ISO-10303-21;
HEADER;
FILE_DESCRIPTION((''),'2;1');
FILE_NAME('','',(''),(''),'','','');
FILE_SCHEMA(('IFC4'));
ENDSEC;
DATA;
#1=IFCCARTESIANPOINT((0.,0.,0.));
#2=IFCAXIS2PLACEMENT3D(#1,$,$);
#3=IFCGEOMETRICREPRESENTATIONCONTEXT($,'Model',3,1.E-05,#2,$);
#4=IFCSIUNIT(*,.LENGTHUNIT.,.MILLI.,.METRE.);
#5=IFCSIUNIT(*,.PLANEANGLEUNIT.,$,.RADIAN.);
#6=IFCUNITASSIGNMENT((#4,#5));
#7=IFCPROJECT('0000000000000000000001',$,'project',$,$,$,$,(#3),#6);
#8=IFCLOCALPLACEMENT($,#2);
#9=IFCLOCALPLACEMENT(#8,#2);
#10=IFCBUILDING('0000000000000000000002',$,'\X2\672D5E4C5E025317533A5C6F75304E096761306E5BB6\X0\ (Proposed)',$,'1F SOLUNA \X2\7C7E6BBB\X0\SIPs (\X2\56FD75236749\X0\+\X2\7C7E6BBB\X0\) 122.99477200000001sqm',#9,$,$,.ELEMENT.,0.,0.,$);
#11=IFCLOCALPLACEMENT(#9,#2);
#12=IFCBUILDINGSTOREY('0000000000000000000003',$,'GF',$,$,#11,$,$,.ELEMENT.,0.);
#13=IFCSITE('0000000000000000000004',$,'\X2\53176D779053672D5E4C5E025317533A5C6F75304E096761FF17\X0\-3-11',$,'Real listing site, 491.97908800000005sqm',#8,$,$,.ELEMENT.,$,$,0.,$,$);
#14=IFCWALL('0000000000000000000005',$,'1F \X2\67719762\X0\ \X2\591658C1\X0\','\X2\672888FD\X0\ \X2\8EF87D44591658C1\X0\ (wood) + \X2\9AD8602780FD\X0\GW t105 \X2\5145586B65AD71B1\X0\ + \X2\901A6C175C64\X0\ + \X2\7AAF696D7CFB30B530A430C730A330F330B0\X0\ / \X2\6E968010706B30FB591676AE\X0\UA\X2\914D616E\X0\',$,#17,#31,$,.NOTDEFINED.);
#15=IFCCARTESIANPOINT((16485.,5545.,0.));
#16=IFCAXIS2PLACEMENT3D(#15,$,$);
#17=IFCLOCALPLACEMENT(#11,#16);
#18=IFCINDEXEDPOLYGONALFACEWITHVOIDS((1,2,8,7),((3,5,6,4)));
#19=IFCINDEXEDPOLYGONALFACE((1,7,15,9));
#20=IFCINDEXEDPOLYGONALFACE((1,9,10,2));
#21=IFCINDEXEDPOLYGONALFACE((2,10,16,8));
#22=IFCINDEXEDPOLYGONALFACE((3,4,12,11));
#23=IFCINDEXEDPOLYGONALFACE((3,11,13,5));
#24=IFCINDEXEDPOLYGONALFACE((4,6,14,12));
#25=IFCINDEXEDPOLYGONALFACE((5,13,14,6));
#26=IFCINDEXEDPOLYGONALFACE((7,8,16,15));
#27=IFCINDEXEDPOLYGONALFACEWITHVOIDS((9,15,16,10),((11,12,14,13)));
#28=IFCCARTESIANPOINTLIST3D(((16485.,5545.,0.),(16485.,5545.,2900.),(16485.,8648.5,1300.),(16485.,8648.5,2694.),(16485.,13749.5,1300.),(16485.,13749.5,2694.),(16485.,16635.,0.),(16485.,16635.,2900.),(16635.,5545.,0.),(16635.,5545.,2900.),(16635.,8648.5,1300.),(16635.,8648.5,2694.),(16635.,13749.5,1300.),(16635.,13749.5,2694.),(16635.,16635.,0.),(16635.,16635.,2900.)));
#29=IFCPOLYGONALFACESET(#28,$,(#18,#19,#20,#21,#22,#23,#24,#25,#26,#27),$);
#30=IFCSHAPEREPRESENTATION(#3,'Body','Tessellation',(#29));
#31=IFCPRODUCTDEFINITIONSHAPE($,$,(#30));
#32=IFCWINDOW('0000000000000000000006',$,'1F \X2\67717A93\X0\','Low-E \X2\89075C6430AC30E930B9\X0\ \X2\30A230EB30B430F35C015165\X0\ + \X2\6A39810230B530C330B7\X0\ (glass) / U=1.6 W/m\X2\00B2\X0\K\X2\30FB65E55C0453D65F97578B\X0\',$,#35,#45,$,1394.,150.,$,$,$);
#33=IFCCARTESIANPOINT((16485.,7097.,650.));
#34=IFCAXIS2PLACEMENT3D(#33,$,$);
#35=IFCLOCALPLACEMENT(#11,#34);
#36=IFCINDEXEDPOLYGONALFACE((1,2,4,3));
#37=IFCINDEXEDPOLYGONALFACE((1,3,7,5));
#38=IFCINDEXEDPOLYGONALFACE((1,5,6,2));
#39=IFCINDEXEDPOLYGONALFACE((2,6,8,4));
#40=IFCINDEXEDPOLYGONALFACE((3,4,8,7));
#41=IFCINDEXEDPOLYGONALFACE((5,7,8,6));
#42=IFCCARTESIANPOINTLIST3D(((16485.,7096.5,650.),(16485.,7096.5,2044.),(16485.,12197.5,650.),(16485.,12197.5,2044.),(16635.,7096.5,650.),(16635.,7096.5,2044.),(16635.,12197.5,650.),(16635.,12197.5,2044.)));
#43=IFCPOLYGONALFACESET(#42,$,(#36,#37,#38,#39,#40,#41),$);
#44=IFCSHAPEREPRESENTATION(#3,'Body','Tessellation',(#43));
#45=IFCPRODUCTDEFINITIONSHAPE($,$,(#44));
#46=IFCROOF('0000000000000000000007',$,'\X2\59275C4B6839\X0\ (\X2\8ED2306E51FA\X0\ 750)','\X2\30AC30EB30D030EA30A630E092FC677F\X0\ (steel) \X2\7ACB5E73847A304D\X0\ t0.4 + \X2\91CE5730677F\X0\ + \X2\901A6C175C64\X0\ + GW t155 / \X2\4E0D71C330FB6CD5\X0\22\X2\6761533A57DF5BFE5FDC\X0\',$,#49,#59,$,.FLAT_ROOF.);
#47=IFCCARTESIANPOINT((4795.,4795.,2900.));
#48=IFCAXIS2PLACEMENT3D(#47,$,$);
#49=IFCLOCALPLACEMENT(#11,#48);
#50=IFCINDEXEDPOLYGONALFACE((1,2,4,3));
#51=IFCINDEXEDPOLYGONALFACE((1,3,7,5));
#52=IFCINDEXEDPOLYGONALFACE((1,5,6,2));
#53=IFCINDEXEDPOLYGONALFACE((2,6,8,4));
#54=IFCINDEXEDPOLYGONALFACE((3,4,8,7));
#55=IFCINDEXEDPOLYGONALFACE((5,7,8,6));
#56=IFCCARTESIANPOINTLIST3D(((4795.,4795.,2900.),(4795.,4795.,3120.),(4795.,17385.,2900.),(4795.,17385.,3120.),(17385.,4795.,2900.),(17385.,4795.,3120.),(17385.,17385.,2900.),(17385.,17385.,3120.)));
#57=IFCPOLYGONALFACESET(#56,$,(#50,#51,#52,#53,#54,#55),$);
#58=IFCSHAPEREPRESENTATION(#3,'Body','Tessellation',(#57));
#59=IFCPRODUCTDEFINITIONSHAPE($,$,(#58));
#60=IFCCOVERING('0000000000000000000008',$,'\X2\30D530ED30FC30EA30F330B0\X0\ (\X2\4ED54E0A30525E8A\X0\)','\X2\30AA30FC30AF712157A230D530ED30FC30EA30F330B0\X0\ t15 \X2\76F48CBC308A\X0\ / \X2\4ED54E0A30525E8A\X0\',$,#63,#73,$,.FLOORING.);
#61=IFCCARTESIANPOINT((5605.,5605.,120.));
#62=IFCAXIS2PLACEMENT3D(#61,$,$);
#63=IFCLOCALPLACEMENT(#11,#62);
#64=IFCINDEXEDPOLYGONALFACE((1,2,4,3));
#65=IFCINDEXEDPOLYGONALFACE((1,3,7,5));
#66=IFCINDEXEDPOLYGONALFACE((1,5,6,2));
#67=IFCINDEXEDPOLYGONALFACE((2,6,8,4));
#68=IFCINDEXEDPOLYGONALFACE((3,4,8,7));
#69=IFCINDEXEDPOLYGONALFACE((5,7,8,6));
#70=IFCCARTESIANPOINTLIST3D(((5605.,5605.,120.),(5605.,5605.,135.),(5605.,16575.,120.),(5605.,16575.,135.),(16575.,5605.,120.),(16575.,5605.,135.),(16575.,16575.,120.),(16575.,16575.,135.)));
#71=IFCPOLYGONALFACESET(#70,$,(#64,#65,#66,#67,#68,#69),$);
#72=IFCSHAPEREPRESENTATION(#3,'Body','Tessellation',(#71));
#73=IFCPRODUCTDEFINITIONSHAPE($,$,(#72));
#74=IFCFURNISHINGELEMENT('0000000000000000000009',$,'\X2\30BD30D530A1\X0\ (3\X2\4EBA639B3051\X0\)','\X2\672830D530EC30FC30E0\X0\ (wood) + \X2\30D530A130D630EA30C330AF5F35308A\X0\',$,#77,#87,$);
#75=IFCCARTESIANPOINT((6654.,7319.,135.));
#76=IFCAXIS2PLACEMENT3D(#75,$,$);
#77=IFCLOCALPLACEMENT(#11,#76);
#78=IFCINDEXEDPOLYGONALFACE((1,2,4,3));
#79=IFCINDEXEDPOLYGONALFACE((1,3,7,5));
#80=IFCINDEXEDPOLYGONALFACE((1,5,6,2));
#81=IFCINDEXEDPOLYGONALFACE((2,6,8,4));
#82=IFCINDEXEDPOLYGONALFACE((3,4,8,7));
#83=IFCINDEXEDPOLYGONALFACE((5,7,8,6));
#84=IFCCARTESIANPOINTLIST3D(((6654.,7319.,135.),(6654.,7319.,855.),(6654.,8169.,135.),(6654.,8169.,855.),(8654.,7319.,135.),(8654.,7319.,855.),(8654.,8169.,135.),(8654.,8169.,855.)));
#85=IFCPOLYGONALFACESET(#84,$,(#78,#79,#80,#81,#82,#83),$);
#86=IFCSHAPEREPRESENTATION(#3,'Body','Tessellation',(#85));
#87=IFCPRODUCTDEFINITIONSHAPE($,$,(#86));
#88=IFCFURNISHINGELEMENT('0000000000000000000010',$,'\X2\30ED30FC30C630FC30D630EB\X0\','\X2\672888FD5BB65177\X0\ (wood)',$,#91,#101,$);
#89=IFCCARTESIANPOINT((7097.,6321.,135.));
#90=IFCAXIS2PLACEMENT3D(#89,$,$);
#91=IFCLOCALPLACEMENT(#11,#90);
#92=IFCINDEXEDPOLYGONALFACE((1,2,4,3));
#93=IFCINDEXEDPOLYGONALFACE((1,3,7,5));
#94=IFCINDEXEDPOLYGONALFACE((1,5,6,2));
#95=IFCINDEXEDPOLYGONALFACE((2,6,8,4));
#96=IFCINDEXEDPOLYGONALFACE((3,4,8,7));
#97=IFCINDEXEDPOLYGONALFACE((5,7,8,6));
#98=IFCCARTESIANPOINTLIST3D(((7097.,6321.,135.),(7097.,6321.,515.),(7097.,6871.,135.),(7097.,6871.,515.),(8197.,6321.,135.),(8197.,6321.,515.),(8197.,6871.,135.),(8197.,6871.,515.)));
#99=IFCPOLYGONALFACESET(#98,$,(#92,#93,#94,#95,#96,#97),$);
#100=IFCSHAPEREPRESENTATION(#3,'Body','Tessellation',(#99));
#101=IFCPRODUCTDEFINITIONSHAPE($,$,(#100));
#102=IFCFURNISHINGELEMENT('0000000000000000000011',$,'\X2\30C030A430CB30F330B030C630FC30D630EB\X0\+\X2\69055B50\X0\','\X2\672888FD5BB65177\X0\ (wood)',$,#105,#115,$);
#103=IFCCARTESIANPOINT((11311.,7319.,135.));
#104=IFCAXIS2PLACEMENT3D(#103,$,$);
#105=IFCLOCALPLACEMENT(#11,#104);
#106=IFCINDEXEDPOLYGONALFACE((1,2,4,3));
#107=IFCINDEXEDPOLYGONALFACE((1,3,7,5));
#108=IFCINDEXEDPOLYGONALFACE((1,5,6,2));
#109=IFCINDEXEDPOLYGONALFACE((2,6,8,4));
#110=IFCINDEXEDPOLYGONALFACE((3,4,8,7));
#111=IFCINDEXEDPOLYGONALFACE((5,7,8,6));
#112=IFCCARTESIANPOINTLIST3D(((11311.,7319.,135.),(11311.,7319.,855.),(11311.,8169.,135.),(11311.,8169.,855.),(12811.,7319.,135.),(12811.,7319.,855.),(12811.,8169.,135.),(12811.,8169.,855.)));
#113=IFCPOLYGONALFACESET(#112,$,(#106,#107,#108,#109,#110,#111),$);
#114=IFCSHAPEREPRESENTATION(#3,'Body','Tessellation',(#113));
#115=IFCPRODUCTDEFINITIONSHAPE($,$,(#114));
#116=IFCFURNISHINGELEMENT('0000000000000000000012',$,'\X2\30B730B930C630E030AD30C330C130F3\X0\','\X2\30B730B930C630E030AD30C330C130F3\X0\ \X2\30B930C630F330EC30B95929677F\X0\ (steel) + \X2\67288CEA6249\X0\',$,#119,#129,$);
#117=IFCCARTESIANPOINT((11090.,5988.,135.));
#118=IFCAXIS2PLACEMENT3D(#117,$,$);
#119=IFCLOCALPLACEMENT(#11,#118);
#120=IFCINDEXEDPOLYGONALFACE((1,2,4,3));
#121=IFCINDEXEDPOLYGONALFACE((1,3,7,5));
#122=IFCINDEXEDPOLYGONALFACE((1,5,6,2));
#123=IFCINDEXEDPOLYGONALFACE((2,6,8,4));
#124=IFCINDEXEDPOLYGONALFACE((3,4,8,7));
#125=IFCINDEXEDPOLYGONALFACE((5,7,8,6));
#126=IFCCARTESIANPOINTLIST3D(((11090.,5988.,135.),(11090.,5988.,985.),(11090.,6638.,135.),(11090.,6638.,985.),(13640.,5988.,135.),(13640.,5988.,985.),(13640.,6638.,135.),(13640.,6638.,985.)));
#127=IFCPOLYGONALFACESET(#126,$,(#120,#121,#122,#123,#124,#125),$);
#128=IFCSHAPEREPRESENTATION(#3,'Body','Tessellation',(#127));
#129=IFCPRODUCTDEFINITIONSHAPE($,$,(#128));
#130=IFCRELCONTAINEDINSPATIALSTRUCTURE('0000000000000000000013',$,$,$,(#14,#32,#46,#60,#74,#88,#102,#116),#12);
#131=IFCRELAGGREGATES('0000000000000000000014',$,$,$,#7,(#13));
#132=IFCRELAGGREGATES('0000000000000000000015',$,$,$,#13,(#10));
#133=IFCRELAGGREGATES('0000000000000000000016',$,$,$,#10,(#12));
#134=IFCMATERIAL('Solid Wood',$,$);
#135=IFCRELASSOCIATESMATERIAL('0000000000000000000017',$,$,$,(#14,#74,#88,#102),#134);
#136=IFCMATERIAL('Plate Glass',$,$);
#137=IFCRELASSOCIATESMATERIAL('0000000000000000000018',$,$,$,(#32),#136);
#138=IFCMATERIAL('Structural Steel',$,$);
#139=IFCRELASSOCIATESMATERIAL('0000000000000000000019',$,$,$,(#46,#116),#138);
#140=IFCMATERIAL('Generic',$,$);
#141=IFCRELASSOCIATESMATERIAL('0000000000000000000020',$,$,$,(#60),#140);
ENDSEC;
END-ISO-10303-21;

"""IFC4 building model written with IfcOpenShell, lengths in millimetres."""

from ifc_helpers import new_model, si_unit, frame, frame_2d, origin, place, context, project, spatial, rectangle, extrude, material, element, fill, save


model = new_model("IFC4")

# Units and contexts
model_context = context("Model", 3, precision=1e-05, world=origin())
ifc_project = project(units=[si_unit("LENGTHUNIT", "METRE", prefix="MILLI"), si_unit("PLANEANGLEUNIT", "RADIAN")], contexts=[model_context])

# Site, building, storey
site_placement = place(None, origin())
site = spatial("IfcSite", under=ifc_project, at=site_placement, Name="北海道札幌市北区屯田三条７-3-11", ObjectType="Real listing site, 491.97908800000005sqm", CompositionType="ELEMENT", RefElevation=0.0)
building_placement = place(site_placement, origin())
building = spatial("IfcBuilding", under=site, at=building_placement, Name="札幌市北区屯田三条の家 (Proposed)", ObjectType="1F SOLUNA 籾殻SIPs (国産杉+籾殻) 122.99477200000001sqm", CompositionType="ELEMENT", ElevationOfRefHeight=0.0, ElevationOfTerrain=0.0)
storey_placement = place(building_placement, origin())
storey = spatial("IfcBuildingStorey", under=building, at=storey_placement, Name="GF", CompositionType="ELEMENT", Elevation=0.0)

# Shared definitions
ifc_material_1 = material(Name="Solid Wood")

# Shared definitions
ifc_material_2 = material(Name="Plate Glass")

# Wall, opening, window
wall_1_placement = place(storey_placement, frame((16485.0, 5545.0, 0.0)))
wall_1 = element("IfcWall", 1, at=wall_1_placement, inside=storey, material=ifc_material_1, Name="1F 東面 外壁", Description="木製 軸組外壁 (wood) + 高性能GW t105 充填断熱 + 通気層 + 窯業系サイディング / 準耐火・外皮UA配慮", PredefinedType="NOTDEFINED", context=model_context, shape_type="SweptSolid", body=[
    extrude(rectangle(XDim=150.0, YDim=11090.0, at=frame_2d((75.0, 5545.0))), frame((16485.0, 5545.0, 0.0)), (0.0, 0.0, 1.0), 2900.0),
])
opening_1_placement = place(storey_placement, frame((16485.0, 7097.0, 650.0)))
opening_1 = element("IfcOpeningElement", 2, at=opening_1_placement, cuts=wall_1, PredefinedType="NOTDEFINED", context=model_context, shape_type="SweptSolid", body=[
    extrude(rectangle(XDim=150.0, YDim=5101.0, at=frame_2d((75.0, 2550.0))), frame((16485.0, 7097.0, 650.0)), (0.0, 0.0, 1.0), 1394.0),
])
window_1_placement = place(storey_placement, frame((16485.0, 7097.0, 650.0)))
window_1 = element("IfcWindow", 3, at=window_1_placement, inside=storey, material=ifc_material_2, Name="1F 東窓", Description="Low-E 複層ガラス アルゴン封入 + 樹脂サッシ (glass) / U=1.6 W/m²K・日射取得型", OverallHeight=1394.0, OverallWidth=150.0, context=model_context, shape_type="SweptSolid", body=[
    extrude(rectangle(XDim=150.0, YDim=5101.0, at=frame_2d((75.0, 2550.0))), frame((16485.0, 7097.0, 650.0)), (0.0, 0.0, 1.0), 1394.0),
])
fill(opening_1, window_1)

# Roof
ifc_material_3 = material(Name="Structural Steel")
roof_placement = place(storey_placement, frame((4795.0, 4795.0, 2900.0)))
element("IfcRoof", 4, at=roof_placement, inside=storey, material=ifc_material_3, Name="大屋根 (軒の出 750)", Description="ガルバリウム鋼板 (steel) 立平葺き t0.4 + 野地板 + 通気層 + GW t155 / 不燃・法22条区域対応", PredefinedType="FLAT_ROOF", context=model_context, shape_type="SweptSolid", body=[
    extrude(rectangle(XDim=12590.0, YDim=12590.0, at=frame_2d((6295.0, 6295.0))), frame((4795.0, 4795.0, 2900.0)), (0.0, 0.0, 1.0), 220.0),
])

# Covering
ifc_material_4 = material(Name="Generic")
covering_placement = place(storey_placement, frame((5605.0, 5605.0, 120.0)))
element("IfcCovering", 5, at=covering_placement, inside=storey, material=ifc_material_4, Name="フローリング (仕上げ床)", Description="オーク無垢フローリング t15 直貼り / 仕上げ床", PredefinedType="FLOORING", context=model_context, shape_type="SweptSolid", body=[
    extrude(rectangle(XDim=10970.0, YDim=10970.0, at=frame_2d((5485.0, 5485.0))), frame((5605.0, 5605.0, 120.0)), (0.0, 0.0, 1.0), 15.0),
])

# Furnishing elements
furnishing_1_placement = place(storey_placement, frame((6654.0, 7319.0, 135.0)))
element("IfcFurnishingElement", 6, at=furnishing_1_placement, inside=storey, material=ifc_material_1, Name="ソファ (3人掛け)", Description="木フレーム (wood) + ファブリック張り", context=model_context, shape_type="SweptSolid", body=[
    extrude(rectangle(XDim=2000.0, YDim=850.0, at=frame_2d((1000.0, 425.0))), frame((6654.0, 7319.0, 135.0)), (0.0, 0.0, 1.0), 720.0),
])
furnishing_2_placement = place(storey_placement, frame((7097.0, 6321.0, 135.0)))
element("IfcFurnishingElement", 7, at=furnishing_2_placement, inside=storey, material=ifc_material_1, Name="ローテーブル", Description="木製家具 (wood)", context=model_context, shape_type="SweptSolid", body=[
    extrude(rectangle(XDim=1100.0, YDim=550.0, at=frame_2d((550.0, 275.0))), frame((7097.0, 6321.0, 135.0)), (0.0, 0.0, 1.0), 380.0),
])
furnishing_3_placement = place(storey_placement, frame((11311.0, 7319.0, 135.0)))
element("IfcFurnishingElement", 8, at=furnishing_3_placement, inside=storey, material=ifc_material_1, Name="ダイニングテーブル+椅子", Description="木製家具 (wood)", context=model_context, shape_type="SweptSolid", body=[
    extrude(rectangle(XDim=1500.0, YDim=850.0, at=frame_2d((750.0, 425.0))), frame((11311.0, 7319.0, 135.0)), (0.0, 0.0, 1.0), 720.0),
])
furnishing_4_placement = place(storey_placement, frame((11090.0, 5988.0, 135.0)))
element("IfcFurnishingElement", 9, at=furnishing_4_placement, inside=storey, material=ifc_material_3, Name="システムキッチン", Description="システムキッチン ステンレス天板 (steel) + 木質扉", context=model_context, shape_type="SweptSolid", body=[
    extrude(rectangle(XDim=2550.0, YDim=650.0, at=frame_2d((1275.0, 325.0))), frame((11090.0, 5988.0, 135.0)), (0.0, 0.0, 1.0), 850.0),
])

save(model, "model.ifc")
